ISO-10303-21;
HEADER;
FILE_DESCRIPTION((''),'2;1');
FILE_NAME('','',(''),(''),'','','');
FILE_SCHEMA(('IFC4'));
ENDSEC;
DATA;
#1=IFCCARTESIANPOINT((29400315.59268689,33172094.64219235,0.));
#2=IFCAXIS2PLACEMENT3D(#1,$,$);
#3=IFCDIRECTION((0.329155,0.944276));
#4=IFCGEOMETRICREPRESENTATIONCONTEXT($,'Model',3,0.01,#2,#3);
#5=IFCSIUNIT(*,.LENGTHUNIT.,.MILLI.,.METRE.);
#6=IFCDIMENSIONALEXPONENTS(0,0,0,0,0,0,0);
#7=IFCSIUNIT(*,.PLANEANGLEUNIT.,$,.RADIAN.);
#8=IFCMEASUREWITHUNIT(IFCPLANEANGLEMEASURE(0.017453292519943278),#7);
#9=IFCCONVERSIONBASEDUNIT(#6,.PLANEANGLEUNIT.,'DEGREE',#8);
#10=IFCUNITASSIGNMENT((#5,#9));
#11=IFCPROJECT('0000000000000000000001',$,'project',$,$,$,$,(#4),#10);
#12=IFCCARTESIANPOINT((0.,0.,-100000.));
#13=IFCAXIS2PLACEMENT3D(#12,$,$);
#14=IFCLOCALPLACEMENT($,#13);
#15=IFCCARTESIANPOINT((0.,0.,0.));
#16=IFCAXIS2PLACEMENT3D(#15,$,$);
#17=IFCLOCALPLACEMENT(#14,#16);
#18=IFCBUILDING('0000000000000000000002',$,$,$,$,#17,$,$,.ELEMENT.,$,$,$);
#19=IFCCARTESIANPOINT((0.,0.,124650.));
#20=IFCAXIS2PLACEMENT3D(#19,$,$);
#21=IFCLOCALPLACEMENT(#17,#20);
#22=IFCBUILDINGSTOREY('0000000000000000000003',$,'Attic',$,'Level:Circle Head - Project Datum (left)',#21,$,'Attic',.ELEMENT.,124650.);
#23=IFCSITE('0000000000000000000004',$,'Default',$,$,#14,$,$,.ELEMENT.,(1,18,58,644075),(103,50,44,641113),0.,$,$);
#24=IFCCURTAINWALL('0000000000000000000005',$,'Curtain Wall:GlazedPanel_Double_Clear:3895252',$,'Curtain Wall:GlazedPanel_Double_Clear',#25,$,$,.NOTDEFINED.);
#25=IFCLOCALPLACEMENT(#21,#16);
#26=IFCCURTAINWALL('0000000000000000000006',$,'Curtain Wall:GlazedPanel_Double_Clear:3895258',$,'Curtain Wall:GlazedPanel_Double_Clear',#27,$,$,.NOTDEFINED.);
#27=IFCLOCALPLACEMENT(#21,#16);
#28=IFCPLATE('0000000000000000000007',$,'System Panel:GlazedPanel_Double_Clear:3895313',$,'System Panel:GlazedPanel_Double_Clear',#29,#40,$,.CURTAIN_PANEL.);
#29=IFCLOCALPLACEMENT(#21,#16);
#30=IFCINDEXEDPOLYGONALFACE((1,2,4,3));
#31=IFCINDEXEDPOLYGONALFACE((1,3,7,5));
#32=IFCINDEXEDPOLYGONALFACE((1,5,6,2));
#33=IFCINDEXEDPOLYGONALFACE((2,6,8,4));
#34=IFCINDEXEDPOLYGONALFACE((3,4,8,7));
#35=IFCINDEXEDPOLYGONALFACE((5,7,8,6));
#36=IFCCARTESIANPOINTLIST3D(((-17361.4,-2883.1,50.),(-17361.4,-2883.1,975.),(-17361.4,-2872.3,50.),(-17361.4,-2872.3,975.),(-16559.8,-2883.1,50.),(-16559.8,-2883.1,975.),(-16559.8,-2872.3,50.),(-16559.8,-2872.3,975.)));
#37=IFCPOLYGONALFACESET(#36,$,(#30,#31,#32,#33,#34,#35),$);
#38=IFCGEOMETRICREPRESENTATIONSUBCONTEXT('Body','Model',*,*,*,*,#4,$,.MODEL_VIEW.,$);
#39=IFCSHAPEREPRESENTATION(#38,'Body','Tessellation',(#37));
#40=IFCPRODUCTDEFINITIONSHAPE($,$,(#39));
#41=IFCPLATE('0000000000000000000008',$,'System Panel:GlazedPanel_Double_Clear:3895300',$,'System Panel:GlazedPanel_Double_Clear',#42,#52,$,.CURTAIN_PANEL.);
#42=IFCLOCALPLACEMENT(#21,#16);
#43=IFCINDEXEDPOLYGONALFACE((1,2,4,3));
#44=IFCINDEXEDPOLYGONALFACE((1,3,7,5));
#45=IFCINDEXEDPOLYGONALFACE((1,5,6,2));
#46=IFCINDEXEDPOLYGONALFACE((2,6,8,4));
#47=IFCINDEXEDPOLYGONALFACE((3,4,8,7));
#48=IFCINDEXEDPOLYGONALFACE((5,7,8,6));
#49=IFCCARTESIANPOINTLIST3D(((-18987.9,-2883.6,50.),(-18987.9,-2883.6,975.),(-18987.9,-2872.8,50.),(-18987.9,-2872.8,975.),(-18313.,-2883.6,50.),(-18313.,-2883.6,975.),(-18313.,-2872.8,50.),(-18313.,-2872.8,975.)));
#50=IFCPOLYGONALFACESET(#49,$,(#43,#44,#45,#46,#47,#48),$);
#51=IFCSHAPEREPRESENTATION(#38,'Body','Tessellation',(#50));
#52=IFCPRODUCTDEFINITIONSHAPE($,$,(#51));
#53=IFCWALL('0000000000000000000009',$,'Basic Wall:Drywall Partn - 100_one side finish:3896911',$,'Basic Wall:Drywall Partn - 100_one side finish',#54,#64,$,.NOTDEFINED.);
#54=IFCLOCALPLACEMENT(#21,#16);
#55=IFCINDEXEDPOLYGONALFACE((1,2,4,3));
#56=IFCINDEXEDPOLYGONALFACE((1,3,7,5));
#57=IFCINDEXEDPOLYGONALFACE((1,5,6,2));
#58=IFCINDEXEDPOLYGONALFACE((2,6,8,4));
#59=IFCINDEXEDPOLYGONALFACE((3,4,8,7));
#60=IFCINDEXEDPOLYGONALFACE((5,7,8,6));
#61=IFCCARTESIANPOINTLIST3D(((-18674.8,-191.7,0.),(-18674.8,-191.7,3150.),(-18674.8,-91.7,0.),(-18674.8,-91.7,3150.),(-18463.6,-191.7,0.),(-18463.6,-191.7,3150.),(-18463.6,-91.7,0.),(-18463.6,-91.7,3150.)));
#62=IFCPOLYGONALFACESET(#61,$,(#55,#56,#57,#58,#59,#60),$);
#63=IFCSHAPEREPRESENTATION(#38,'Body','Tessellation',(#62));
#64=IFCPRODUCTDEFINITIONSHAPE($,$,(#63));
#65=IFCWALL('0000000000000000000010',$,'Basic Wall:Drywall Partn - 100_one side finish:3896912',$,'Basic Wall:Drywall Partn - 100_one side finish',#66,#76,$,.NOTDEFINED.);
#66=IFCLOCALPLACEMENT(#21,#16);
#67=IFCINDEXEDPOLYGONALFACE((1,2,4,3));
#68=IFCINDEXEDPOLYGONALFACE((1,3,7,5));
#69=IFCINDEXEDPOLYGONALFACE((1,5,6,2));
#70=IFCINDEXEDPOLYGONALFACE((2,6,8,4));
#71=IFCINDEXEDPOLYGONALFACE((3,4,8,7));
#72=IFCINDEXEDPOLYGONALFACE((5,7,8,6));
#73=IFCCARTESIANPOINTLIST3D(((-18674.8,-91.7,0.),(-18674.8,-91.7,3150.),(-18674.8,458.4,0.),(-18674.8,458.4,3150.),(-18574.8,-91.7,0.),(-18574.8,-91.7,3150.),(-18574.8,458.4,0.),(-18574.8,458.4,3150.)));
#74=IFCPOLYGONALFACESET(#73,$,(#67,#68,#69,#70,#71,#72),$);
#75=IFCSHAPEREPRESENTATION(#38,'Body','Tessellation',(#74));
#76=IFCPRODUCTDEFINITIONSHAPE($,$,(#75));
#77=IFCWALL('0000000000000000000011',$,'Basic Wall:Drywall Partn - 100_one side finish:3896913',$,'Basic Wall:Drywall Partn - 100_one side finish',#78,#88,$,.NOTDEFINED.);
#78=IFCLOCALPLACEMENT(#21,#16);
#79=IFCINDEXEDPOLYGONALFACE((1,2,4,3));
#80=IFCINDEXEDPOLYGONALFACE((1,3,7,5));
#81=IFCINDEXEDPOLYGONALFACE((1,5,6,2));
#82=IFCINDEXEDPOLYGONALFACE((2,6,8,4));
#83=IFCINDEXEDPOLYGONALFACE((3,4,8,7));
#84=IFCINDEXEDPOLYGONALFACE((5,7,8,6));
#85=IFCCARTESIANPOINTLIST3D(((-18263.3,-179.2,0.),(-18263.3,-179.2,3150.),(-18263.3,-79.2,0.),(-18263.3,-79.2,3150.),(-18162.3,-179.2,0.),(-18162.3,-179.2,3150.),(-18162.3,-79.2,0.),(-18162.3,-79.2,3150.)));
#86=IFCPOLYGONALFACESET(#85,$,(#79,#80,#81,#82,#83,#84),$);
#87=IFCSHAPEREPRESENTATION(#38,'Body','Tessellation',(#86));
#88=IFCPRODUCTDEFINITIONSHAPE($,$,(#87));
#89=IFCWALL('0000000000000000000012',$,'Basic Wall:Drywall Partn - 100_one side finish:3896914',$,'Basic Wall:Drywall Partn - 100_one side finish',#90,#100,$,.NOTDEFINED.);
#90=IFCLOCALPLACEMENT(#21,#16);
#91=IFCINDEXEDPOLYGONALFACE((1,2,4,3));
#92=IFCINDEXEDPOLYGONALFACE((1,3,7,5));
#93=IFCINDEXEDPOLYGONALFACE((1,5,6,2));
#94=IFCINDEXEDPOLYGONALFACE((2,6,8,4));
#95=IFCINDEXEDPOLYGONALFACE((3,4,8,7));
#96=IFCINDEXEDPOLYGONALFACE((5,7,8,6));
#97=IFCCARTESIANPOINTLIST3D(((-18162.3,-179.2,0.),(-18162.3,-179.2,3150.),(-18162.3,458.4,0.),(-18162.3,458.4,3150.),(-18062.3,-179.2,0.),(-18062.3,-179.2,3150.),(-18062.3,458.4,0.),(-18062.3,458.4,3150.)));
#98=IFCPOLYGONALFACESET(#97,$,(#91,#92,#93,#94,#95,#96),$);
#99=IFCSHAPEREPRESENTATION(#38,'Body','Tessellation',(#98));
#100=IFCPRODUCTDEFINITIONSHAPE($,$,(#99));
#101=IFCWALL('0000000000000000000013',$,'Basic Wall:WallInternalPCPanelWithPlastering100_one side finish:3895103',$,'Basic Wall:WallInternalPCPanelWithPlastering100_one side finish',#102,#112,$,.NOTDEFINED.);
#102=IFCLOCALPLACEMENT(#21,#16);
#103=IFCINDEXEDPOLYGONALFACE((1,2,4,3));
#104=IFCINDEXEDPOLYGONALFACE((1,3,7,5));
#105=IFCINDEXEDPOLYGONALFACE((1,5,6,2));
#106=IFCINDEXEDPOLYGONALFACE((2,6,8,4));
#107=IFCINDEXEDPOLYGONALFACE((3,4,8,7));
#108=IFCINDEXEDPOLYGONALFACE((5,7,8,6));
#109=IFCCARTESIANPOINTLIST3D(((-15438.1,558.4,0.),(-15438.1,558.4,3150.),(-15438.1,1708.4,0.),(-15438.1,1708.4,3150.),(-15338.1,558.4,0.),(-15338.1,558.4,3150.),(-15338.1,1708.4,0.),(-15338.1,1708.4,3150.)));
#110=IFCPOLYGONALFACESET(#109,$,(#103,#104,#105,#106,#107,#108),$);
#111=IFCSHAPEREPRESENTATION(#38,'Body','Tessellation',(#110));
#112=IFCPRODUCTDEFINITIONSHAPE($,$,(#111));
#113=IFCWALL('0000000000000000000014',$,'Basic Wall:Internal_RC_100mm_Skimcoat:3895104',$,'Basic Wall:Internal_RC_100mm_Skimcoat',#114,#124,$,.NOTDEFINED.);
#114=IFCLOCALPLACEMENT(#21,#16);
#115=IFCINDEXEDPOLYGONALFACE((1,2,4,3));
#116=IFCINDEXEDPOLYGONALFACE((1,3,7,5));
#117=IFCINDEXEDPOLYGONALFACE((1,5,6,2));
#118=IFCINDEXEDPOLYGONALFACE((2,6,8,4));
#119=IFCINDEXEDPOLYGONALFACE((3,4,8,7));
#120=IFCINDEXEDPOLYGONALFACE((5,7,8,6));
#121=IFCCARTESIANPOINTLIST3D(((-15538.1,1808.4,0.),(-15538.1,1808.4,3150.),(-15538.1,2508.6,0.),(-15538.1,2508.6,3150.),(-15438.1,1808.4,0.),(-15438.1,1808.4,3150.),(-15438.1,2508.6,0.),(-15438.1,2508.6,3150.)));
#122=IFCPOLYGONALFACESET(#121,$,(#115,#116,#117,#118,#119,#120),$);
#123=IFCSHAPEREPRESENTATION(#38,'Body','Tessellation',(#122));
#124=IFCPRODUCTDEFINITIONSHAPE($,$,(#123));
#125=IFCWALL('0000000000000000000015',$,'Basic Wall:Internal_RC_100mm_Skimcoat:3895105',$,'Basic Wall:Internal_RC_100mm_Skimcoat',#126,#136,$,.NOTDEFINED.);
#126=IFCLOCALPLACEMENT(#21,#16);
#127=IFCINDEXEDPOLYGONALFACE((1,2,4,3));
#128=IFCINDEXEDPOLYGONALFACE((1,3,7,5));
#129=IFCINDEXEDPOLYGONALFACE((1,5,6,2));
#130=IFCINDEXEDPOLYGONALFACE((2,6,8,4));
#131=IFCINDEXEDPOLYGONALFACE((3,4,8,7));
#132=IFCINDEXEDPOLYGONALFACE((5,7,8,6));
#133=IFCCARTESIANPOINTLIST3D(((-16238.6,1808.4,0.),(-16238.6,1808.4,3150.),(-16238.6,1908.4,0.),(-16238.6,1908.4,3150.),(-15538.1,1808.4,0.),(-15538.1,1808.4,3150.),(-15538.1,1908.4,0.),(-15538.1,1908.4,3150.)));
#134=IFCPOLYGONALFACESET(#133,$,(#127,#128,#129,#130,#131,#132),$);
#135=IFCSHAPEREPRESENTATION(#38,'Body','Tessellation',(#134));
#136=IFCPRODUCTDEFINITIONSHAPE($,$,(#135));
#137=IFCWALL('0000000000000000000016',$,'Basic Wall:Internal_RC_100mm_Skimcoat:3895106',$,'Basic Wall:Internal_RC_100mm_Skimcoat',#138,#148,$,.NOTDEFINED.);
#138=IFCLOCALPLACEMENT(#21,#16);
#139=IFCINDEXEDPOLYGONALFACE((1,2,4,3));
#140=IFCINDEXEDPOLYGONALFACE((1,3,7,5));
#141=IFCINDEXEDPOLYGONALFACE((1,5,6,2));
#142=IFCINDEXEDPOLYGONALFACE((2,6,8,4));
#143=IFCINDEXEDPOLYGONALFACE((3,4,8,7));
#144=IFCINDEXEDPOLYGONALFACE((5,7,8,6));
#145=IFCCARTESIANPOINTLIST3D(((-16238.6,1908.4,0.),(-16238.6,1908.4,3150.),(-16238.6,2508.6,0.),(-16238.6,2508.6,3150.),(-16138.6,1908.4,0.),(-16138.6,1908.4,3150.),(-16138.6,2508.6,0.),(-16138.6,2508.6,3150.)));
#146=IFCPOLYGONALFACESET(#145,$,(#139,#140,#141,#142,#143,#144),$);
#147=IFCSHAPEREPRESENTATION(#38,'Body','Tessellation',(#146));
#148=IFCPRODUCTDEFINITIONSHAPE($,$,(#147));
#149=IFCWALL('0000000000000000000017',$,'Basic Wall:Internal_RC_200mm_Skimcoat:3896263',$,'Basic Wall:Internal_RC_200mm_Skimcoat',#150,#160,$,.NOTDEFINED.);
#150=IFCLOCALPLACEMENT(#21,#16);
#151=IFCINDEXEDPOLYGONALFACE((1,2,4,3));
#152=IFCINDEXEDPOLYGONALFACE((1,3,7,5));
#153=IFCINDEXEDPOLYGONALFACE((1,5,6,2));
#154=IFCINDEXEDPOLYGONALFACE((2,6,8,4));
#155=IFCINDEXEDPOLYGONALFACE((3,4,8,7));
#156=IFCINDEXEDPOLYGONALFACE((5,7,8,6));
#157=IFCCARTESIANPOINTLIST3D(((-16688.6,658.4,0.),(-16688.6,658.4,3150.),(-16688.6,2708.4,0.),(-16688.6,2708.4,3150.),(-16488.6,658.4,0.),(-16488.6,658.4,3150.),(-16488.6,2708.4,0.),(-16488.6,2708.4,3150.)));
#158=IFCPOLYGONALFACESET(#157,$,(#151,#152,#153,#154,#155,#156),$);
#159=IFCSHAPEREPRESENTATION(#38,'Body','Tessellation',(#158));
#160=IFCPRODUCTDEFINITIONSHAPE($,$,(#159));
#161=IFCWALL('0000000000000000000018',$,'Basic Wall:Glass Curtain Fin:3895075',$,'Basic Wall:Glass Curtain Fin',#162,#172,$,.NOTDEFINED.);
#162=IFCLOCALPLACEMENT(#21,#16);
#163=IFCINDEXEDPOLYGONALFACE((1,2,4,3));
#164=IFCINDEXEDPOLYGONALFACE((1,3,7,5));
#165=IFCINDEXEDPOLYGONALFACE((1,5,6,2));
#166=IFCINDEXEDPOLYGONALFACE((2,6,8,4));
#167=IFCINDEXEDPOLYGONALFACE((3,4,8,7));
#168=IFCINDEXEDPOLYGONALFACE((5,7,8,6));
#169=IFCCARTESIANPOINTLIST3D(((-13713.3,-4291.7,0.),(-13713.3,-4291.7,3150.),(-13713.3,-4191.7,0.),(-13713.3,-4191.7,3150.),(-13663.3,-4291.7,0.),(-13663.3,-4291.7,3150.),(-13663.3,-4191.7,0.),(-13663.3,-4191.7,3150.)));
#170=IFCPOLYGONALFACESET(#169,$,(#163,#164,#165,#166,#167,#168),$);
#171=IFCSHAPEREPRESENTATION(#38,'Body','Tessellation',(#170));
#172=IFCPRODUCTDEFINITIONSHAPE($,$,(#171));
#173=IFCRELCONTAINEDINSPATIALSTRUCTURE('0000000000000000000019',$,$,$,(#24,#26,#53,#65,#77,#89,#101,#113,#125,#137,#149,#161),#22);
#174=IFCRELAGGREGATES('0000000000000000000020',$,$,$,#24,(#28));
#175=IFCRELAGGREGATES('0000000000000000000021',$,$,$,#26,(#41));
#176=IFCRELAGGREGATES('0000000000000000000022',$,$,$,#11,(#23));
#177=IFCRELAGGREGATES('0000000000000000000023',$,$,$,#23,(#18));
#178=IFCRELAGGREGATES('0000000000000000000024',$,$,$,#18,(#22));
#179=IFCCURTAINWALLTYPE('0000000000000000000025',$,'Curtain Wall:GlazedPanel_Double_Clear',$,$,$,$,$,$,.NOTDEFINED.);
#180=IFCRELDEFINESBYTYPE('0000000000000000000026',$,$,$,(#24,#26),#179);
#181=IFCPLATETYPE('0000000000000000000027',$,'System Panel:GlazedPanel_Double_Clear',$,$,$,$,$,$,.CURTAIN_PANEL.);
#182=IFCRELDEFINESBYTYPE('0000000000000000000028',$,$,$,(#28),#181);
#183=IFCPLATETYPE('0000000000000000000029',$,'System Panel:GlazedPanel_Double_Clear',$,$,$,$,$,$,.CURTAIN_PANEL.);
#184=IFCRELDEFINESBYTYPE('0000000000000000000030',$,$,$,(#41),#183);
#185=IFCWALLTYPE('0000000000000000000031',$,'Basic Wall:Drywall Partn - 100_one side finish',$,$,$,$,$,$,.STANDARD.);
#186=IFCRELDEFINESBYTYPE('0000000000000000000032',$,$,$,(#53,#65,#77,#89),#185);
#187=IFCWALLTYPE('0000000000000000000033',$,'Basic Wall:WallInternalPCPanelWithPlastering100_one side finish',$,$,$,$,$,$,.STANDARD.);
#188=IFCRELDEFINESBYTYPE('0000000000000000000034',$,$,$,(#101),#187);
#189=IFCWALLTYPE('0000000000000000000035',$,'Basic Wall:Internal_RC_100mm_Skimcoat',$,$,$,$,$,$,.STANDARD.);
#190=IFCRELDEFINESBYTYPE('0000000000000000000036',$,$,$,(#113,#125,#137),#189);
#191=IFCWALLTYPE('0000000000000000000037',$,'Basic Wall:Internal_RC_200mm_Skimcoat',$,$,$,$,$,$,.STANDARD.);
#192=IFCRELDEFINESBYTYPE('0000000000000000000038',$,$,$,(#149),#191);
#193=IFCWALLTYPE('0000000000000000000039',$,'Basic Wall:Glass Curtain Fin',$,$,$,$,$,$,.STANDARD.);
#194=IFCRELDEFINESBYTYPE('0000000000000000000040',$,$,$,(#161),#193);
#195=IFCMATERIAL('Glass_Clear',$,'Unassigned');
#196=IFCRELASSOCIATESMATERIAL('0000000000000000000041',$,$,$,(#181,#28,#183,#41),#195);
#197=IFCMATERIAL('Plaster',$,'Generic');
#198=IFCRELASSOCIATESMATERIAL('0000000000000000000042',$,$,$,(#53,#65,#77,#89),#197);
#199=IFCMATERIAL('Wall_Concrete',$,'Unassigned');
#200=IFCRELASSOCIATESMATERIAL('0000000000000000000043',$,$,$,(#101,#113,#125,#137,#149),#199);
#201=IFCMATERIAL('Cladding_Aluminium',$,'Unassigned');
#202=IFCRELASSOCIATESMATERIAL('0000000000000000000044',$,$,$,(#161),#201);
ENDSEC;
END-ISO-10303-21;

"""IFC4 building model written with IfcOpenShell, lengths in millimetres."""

from ifc_helpers import new_model, entity, si_unit, converted_unit, direction, frame, origin, place, context, subcontext, project, spatial, indexed_curve, outline, extrude, source, transform, mapped, material, type_object, type_shapes, element, aggregate, save


model = new_model("IFC4")

# Units and contexts
model_context = context("Model", 3, precision=0.01, world=frame((29400315.59268689, 33172094.64219235, 0.0)), true_north=direction((0.329155, 0.944276)))
body_context = subcontext(model_context, "Body", "Model", "MODEL_VIEW")
ifc_project = project(units=[si_unit("LENGTHUNIT", "METRE", prefix="MILLI"), converted_unit("PLANEANGLEUNIT", "DEGREE", entity("IfcPlaneAngleMeasure", 0.017453292519943278), si_unit("PLANEANGLEUNIT", "RADIAN"), dimensions=[0, 0, 0, 0, 0, 0, 0])], contexts=[model_context])

# Site, building, storey
site_placement = place(None, frame((0.0, 0.0, -100000.0)))
site = spatial("IfcSite", under=ifc_project, at=site_placement, Name="Default", CompositionType="ELEMENT", RefLatitude=(1, 18, 58, 644075), RefLongitude=(103, 50, 44, 641113), RefElevation=0.0)
building_placement = place(site_placement, origin())
building = spatial("IfcBuilding", under=site, at=building_placement, CompositionType="ELEMENT")
storey_placement = place(building_placement, frame((0.0, 0.0, 124650.0)))
storey = spatial("IfcBuildingStorey", under=building, at=storey_placement, Name="Attic", ObjectType="Level:Circle Head - Project Datum (left)", LongName="Attic", CompositionType="ELEMENT", Elevation=124650.0)

# Curtain wall
curtain_wall_type = type_object("IfcCurtainWallType", Name="Curtain Wall:GlazedPanel_Double_Clear", PredefinedType="NOTDEFINED")
curtain_wall_1_placement = place(storey_placement, frame((0.0, 0.0, -124650.0)))
curtain_wall_1 = element("IfcCurtainWall", 1, at=curtain_wall_1_placement, inside=storey, type_object=curtain_wall_type, Name="Curtain Wall:GlazedPanel_Double_Clear:3895252", ObjectType="Curtain Wall:GlazedPanel_Double_Clear", PredefinedType="NOTDEFINED")

# Curtain wall
curtain_wall_2_placement = place(storey_placement, frame((0.0, 0.0, -124650.0)))
curtain_wall_2 = element("IfcCurtainWall", 2, at=curtain_wall_2_placement, inside=storey, type_object=curtain_wall_type, Name="Curtain Wall:GlazedPanel_Double_Clear:3895258", ObjectType="Curtain Wall:GlazedPanel_Double_Clear", PredefinedType="NOTDEFINED")

# Plates
ifc_material_1 = material(Name="Glass_Clear", Category="Unassigned")
plate_type_1 = type_object("IfcPlateType", Name="System Panel:GlazedPanel_Double_Clear", PredefinedType="CURTAIN_PANEL", material=ifc_material_1)
shared_shape_1 = source(origin(), body_context, "Body", "SweptSolid", [
    extrude(outline(indexed_curve([(-5.4, -400.8), (5.4, -400.8), (5.4, 400.8), (-5.4, 400.8), (-5.4, -400.8)], self_intersect=False)), frame((0.0, -111.0, 0.0), z_axis=(0.0, 0.0, 1.0), x_axis=(0.0, 1.0, 0.0)), (0.0, 0.0, 1.0), 925.0),
])
type_shapes(plate_type_1, [shared_shape_1])
plate_1_placement = place(curtain_wall_1_placement, frame((-16960.6, -2766.7, 124700.0)))
plate_1 = element("IfcPlate", 3, at=plate_1_placement, type_object=plate_type_1, material=ifc_material_1, Name="System Panel:GlazedPanel_Double_Clear:3895313", ObjectType="System Panel:GlazedPanel_Double_Clear", PredefinedType="CURTAIN_PANEL", context=body_context, shape_type="MappedRepresentation", body=[
    mapped(shared_shape_1, transform((0.0, 0.0, 0.0), scale=1.0)),
])
aggregate(curtain_wall_1, [plate_1])
plate_type_2 = type_object("IfcPlateType", Name="System Panel:GlazedPanel_Double_Clear", PredefinedType="CURTAIN_PANEL", material=ifc_material_1)
shared_shape_2 = source(origin(), body_context, "Body", "SweptSolid", [
    extrude(outline(indexed_curve([(-5.4, -337.5), (5.4, -337.5), (5.4, 337.5), (-5.4, 337.5), (-5.4, -337.5)], self_intersect=False)), frame((0.0, -111.0, 0.0), z_axis=(0.0, 0.0, 1.0), x_axis=(0.0, 1.0, 0.0)), (0.0, 0.0, 1.0), 925.0),
])
type_shapes(plate_type_2, [shared_shape_2])
plate_2_placement = place(curtain_wall_2_placement, frame((-18650.4, -2767.2, 124700.0)))
plate_2 = element("IfcPlate", 4, at=plate_2_placement, type_object=plate_type_2, material=ifc_material_1, Name="System Panel:GlazedPanel_Double_Clear:3895300", ObjectType="System Panel:GlazedPanel_Double_Clear", PredefinedType="CURTAIN_PANEL", context=body_context, shape_type="MappedRepresentation", body=[
    mapped(shared_shape_2, transform((0.0, 0.0, 0.0), scale=1.0)),
])
aggregate(curtain_wall_2, [plate_2])

# Walls
ifc_material_2 = material(Name="Plaster", Category="Generic")
wall_type_1 = type_object("IfcWallType", Name="Basic Wall:Drywall Partn - 100_one side finish", PredefinedType="STANDARD")
wall_1_placement = place(storey_placement, frame((-18463.6, -141.7, 0.0), z_axis=(0.0, 0.0, 1.0), x_axis=(-1.0, 0.0, 0.0)))
element("IfcWall", 5, at=wall_1_placement, inside=storey, type_object=wall_type_1, material=ifc_material_2, Name="Basic Wall:Drywall Partn - 100_one side finish:3896911", ObjectType="Basic Wall:Drywall Partn - 100_one side finish", PredefinedType="NOTDEFINED", context=body_context, shape_type="SweptSolid", body=[
    extrude(outline(indexed_curve([(211.2, 50.0), (0.0, 50.0), (0.0, -50.0), (211.2, -50.0), (211.2, 50.0)], self_intersect=False)), origin(), (0.0, 0.0, 1.0), 3150.0),
])
wall_2_placement = place(storey_placement, frame((-18624.8, -91.7, 0.0), z_axis=(0.0, 0.0, 1.0), x_axis=(0.0, 1.0, 0.0)))
element("IfcWall", 6, at=wall_2_placement, inside=storey, type_object=wall_type_1, material=ifc_material_2, Name="Basic Wall:Drywall Partn - 100_one side finish:3896912", ObjectType="Basic Wall:Drywall Partn - 100_one side finish", PredefinedType="NOTDEFINED", context=body_context, shape_type="SweptSolid", body=[
    extrude(outline(indexed_curve([(550.1, 50.0), (0.0, 50.0), (0.0, -50.0), (550.1, -50.0), (550.1, 50.0)], self_intersect=False)), origin(), (0.0, 0.0, 1.0), 3150.0),
])
wall_3_placement = place(storey_placement, frame((-18162.3, -129.2, 0.0), z_axis=(0.0, 0.0, 1.0), x_axis=(-1.0, 0.0, 0.0)))
element("IfcWall", 7, at=wall_3_placement, inside=storey, type_object=wall_type_1, material=ifc_material_2, Name="Basic Wall:Drywall Partn - 100_one side finish:3896913", ObjectType="Basic Wall:Drywall Partn - 100_one side finish", PredefinedType="NOTDEFINED", context=body_context, shape_type="SweptSolid", body=[
    extrude(outline(indexed_curve([(101.0, 50.0), (0.0, 50.0), (0.0, -50.0), (101.0, -50.0), (101.0, 50.0)], self_intersect=False)), origin(), (0.0, 0.0, 1.0), 3150.0),
])
wall_4_placement = place(storey_placement, frame((-18112.3, 458.4, 0.0), z_axis=(0.0, 0.0, 1.0), x_axis=(0.0, -1.0, 0.0)))
element("IfcWall", 8, at=wall_4_placement, inside=storey, type_object=wall_type_1, material=ifc_material_2, Name="Basic Wall:Drywall Partn - 100_one side finish:3896914", ObjectType="Basic Wall:Drywall Partn - 100_one side finish", PredefinedType="NOTDEFINED", context=body_context, shape_type="SweptSolid", body=[
    extrude(outline(indexed_curve([(637.6, 50.0), (0.0, 50.0), (0.0, -50.0), (637.6, -50.0), (637.6, 50.0)], self_intersect=False)), origin(), (0.0, 0.0, 1.0), 3150.0),
])
ifc_material_3 = material(Name="Wall_Concrete", Category="Unassigned")
wall_type_2 = type_object("IfcWallType", Name="Basic Wall:WallInternalPCPanelWithPlastering100_one side finish", PredefinedType="STANDARD")
wall_5_placement = place(storey_placement, frame((-15388.1, 558.4, 0.0), z_axis=(0.0, 0.0, 1.0), x_axis=(0.0, 1.0, 0.0)))
element("IfcWall", 9, at=wall_5_placement, inside=storey, type_object=wall_type_2, material=ifc_material_3, Name="Basic Wall:WallInternalPCPanelWithPlastering100_one side finish:3895103", ObjectType="Basic Wall:WallInternalPCPanelWithPlastering100_one side finish", PredefinedType="NOTDEFINED", context=body_context, shape_type="SweptSolid", body=[
    extrude(outline(indexed_curve([(1150.0, 50.0), (0.0, 50.0), (0.0, -50.0), (1150.0, -50.0), (1150.0, 50.0)], self_intersect=False)), origin(), (0.0, 0.0, 1.0), 3150.0),
])
wall_type_3 = type_object("IfcWallType", Name="Basic Wall:Internal_RC_100mm_Skimcoat", PredefinedType="STANDARD")
wall_6_placement = place(storey_placement, frame((-15488.1, 2508.6, 0.0), z_axis=(0.0, 0.0, 1.0), x_axis=(0.0, -1.0, 0.0)))
element("IfcWall", 10, at=wall_6_placement, inside=storey, type_object=wall_type_3, material=ifc_material_3, Name="Basic Wall:Internal_RC_100mm_Skimcoat:3895104", ObjectType="Basic Wall:Internal_RC_100mm_Skimcoat", PredefinedType="NOTDEFINED", context=body_context, shape_type="SweptSolid", body=[
    extrude(outline(indexed_curve([(700.1, 50.0), (0.0, 50.0), (0.0, -50.0), (700.1, -50.0), (700.1, 50.0)], self_intersect=False)), origin(), (0.0, 0.0, 1.0), 3150.0),
])
wall_7_placement = place(storey_placement, frame((-15538.1, 1858.4, 0.0), z_axis=(0.0, 0.0, 1.0), x_axis=(-1.0, 0.0, 0.0)))
element("IfcWall", 11, at=wall_7_placement, inside=storey, type_object=wall_type_3, material=ifc_material_3, Name="Basic Wall:Internal_RC_100mm_Skimcoat:3895105", ObjectType="Basic Wall:Internal_RC_100mm_Skimcoat", PredefinedType="NOTDEFINED", context=body_context, shape_type="SweptSolid", body=[
    extrude(outline(indexed_curve([(700.5, 50.0), (0.0, 50.0), (0.0, -50.0), (700.5, -50.0), (700.5, 50.0)], self_intersect=False)), origin(), (0.0, 0.0, 1.0), 3150.0),
])
wall_8_placement = place(storey_placement, frame((-16188.6, 2508.6, 0.0), z_axis=(0.0, 0.0, 1.0), x_axis=(0.0, -1.0, 0.0)))
element("IfcWall", 12, at=wall_8_placement, inside=storey, type_object=wall_type_3, material=ifc_material_3, Name="Basic Wall:Internal_RC_100mm_Skimcoat:3895106", ObjectType="Basic Wall:Internal_RC_100mm_Skimcoat", PredefinedType="NOTDEFINED", context=body_context, shape_type="SweptSolid", body=[
    extrude(outline(indexed_curve([(600.1, 50.0), (0.0, 50.0), (0.0, -50.0), (600.1, -50.0), (600.1, 50.0)], self_intersect=False)), origin(), (0.0, 0.0, 1.0), 3150.0),
])
wall_type_4 = type_object("IfcWallType", Name="Basic Wall:Internal_RC_200mm_Skimcoat", PredefinedType="STANDARD")
wall_9_placement = place(storey_placement, frame((-16588.6, 658.4, 0.0), z_axis=(0.0, 0.0, 1.0), x_axis=(0.0, 1.0, 0.0)))
element("IfcWall", 13, at=wall_9_placement, inside=storey, type_object=wall_type_4, material=ifc_material_3, Name="Basic Wall:Internal_RC_200mm_Skimcoat:3896263", ObjectType="Basic Wall:Internal_RC_200mm_Skimcoat", PredefinedType="NOTDEFINED", context=body_context, shape_type="SweptSolid", body=[
    extrude(outline(indexed_curve([(2050.0, 100.0), (0.0, 100.0), (0.0, -100.0), (2050.0, -100.0), (2050.0, 100.0)], self_intersect=False)), origin(), (0.0, 0.0, 1.0), 3150.0),
])
ifc_material_4 = material(Name="Cladding_Aluminium", Category="Unassigned")
wall_type_5 = type_object("IfcWallType", Name="Basic Wall:Glass Curtain Fin", PredefinedType="STANDARD")
wall_10_placement = place(storey_placement, frame((-13688.3, -4191.7, 0.0), z_axis=(0.0, 0.0, 1.0), x_axis=(0.0, -1.0, 0.0)))
element("IfcWall", 14, at=wall_10_placement, inside=storey, type_object=wall_type_5, material=ifc_material_4, Name="Basic Wall:Glass Curtain Fin:3895075", ObjectType="Basic Wall:Glass Curtain Fin", PredefinedType="NOTDEFINED", context=body_context, shape_type="SweptSolid", body=[
    extrude(outline(indexed_curve([(100.0, 25.0), (0.0, 25.0), (0.0, -25.0), (100.0, -25.0), (100.0, 25.0)], self_intersect=False)), origin(), (0.0, 0.0, 1.0), 3150.0),
])

save(model, "model.ifc")
